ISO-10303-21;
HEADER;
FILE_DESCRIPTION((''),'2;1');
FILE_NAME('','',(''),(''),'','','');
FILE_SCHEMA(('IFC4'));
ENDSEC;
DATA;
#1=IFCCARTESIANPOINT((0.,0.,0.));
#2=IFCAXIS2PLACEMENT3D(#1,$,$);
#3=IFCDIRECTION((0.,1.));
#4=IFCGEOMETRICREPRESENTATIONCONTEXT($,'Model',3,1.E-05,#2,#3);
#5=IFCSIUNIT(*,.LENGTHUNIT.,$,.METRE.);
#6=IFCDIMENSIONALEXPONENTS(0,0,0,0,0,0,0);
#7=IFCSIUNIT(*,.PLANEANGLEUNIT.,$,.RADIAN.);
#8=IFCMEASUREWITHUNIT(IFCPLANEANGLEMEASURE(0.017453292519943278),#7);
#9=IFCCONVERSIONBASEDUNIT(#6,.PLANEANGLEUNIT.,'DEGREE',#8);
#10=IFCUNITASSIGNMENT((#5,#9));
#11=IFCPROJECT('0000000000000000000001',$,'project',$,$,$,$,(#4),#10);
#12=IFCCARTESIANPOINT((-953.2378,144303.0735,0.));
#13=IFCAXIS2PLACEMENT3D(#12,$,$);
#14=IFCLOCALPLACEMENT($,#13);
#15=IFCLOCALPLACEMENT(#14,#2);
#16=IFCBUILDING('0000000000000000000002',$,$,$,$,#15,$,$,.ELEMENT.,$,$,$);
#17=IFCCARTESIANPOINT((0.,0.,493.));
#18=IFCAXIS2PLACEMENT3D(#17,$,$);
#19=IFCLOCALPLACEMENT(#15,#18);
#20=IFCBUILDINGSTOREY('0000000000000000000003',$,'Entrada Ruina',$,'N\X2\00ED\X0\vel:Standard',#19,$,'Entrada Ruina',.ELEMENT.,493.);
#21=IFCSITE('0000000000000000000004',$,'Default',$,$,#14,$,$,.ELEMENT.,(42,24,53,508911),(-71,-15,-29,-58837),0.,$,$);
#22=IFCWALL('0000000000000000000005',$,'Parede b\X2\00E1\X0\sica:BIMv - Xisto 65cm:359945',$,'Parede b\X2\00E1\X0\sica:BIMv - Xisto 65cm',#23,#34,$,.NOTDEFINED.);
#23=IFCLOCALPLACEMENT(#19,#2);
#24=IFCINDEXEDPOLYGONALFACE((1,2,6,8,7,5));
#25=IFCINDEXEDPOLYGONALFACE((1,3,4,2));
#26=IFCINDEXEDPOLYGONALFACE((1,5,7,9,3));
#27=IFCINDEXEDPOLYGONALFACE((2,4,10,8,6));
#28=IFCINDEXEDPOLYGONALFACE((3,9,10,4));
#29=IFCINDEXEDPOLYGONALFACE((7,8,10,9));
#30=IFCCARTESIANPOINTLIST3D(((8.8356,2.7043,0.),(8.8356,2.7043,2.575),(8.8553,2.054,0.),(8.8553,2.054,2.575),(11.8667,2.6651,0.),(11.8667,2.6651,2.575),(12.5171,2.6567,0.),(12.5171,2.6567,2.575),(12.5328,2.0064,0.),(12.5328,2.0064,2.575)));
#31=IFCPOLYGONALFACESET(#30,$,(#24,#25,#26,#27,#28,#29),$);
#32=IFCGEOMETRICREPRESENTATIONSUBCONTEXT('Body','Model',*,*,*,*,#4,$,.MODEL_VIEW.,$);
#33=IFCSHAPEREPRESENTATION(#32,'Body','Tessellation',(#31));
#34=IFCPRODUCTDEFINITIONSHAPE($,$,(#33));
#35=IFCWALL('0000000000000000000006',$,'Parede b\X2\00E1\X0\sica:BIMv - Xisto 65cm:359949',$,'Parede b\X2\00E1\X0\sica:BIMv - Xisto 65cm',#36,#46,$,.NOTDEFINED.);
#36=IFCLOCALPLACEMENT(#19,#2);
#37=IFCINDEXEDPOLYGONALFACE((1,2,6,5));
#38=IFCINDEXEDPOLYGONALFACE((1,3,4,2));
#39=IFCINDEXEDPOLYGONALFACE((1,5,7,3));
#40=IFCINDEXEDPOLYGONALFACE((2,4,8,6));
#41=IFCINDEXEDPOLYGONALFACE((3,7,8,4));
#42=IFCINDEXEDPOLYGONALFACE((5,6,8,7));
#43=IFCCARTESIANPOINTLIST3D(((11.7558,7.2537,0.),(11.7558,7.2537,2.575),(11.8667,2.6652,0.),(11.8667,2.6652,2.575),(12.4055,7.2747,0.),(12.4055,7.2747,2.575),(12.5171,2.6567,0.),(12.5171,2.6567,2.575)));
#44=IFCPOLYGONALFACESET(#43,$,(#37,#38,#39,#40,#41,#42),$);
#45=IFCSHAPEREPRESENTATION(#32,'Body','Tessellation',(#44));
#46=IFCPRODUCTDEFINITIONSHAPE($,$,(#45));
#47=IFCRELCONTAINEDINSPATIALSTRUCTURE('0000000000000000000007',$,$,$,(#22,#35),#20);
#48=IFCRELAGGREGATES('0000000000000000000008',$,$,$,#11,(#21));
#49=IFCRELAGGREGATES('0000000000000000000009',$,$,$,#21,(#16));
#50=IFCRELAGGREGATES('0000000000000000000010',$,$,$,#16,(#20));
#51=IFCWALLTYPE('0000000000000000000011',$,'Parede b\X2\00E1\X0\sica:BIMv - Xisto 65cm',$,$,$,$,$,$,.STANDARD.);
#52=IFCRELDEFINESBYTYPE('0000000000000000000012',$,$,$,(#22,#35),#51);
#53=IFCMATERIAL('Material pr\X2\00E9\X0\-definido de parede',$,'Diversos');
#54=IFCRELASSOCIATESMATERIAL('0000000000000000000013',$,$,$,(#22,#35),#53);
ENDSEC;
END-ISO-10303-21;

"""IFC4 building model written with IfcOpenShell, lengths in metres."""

from ifc_helpers import new_model, entity, si_unit, converted_unit, direction, frame, origin, place, context, subcontext, project, spatial, indexed_curve, outline, extrude, material, type_object, element, save


model = new_model("IFC4")

# Units and contexts
model_context = context("Model", 3, precision=1e-05, world=origin(), true_north=direction((0.0, 1.0)))
body_context = subcontext(model_context, "Body", "Model", "MODEL_VIEW")
ifc_project = project(units=[si_unit("LENGTHUNIT", "METRE"), converted_unit("PLANEANGLEUNIT", "DEGREE", entity("IfcPlaneAngleMeasure", 0.017453292519943278), si_unit("PLANEANGLEUNIT", "RADIAN"), dimensions=[0, 0, 0, 0, 0, 0, 0])], contexts=[model_context])

# Site, building, storey
site_placement = place(None, frame((-953.2378, 144303.0735, 0.0)))
site = spatial("IfcSite", under=ifc_project, at=site_placement, Name="Default", CompositionType="ELEMENT", RefLatitude=(42, 24, 53, 508911), RefLongitude=(-71, -15, -29, -58837), RefElevation=0.0)
building_placement = place(site_placement, origin())
building = spatial("IfcBuilding", under=site, at=building_placement, CompositionType="ELEMENT")
storey_placement = place(building_placement, frame((0.0, 0.0, 493.0)))
storey = spatial("IfcBuildingStorey", under=building, at=storey_placement, Name="Entrada Ruina", ObjectType="Nível:Standard", LongName="Entrada Ruina", CompositionType="ELEMENT", Elevation=493.0)

# Walls
ifc_material_1 = material(Name="Material pré-definido de parede", Category="Diversos")
wall_type_1 = type_object("IfcWallType", Name="Parede básica:BIMv - Xisto 65cm", PredefinedType="STANDARD")
wall_1_placement = place(storey_placement, frame((12.537, 2.3314, 0.0), z_axis=(0.0, 0.0, 1.0), x_axis=(-0.999916, 0.012938, 0.0)))
element("IfcWall", 1, at=wall_1_placement, inside=storey, type_object=wall_type_1, material=ifc_material_1, Name="Parede básica:BIMv - Xisto 65cm:359945", ObjectType="Parede básica:BIMv - Xisto 65cm", PredefinedType="NOTDEFINED", context=body_context, shape_type="SweptSolid", body=[
    extrude(outline(indexed_curve([(3.7059, -0.325), (3.6778, 0.325), (0.0, 0.325), (0.0241, -0.325), (0.6746, -0.325), (3.7059, -0.325)], self_intersect=False)), origin(), (0.0, 0.0, 1.0), 2.575),
])
wall_2_placement = place(storey_placement, frame((12.0806, 7.2668, 0.0), z_axis=(0.0, 0.0, 1.0), x_axis=(0.024156, -0.999708, 0.0)))
element("IfcWall", 2, at=wall_2_placement, inside=storey, type_object=wall_type_1, material=ifc_material_1, Name="Parede básica:BIMv - Xisto 65cm:359949", ObjectType="Parede básica:BIMv - Xisto 65cm", PredefinedType="NOTDEFINED", context=body_context, shape_type="SweptSolid", body=[
    extrude(outline(indexed_curve([(4.5951, -0.325), (4.6193, 0.325), (0.0, 0.325), (0.0053, -0.325), (4.5951, -0.325)], self_intersect=False)), origin(), (0.0, 0.0, 1.0), 2.575),
])

save(model, "model.ifc")
